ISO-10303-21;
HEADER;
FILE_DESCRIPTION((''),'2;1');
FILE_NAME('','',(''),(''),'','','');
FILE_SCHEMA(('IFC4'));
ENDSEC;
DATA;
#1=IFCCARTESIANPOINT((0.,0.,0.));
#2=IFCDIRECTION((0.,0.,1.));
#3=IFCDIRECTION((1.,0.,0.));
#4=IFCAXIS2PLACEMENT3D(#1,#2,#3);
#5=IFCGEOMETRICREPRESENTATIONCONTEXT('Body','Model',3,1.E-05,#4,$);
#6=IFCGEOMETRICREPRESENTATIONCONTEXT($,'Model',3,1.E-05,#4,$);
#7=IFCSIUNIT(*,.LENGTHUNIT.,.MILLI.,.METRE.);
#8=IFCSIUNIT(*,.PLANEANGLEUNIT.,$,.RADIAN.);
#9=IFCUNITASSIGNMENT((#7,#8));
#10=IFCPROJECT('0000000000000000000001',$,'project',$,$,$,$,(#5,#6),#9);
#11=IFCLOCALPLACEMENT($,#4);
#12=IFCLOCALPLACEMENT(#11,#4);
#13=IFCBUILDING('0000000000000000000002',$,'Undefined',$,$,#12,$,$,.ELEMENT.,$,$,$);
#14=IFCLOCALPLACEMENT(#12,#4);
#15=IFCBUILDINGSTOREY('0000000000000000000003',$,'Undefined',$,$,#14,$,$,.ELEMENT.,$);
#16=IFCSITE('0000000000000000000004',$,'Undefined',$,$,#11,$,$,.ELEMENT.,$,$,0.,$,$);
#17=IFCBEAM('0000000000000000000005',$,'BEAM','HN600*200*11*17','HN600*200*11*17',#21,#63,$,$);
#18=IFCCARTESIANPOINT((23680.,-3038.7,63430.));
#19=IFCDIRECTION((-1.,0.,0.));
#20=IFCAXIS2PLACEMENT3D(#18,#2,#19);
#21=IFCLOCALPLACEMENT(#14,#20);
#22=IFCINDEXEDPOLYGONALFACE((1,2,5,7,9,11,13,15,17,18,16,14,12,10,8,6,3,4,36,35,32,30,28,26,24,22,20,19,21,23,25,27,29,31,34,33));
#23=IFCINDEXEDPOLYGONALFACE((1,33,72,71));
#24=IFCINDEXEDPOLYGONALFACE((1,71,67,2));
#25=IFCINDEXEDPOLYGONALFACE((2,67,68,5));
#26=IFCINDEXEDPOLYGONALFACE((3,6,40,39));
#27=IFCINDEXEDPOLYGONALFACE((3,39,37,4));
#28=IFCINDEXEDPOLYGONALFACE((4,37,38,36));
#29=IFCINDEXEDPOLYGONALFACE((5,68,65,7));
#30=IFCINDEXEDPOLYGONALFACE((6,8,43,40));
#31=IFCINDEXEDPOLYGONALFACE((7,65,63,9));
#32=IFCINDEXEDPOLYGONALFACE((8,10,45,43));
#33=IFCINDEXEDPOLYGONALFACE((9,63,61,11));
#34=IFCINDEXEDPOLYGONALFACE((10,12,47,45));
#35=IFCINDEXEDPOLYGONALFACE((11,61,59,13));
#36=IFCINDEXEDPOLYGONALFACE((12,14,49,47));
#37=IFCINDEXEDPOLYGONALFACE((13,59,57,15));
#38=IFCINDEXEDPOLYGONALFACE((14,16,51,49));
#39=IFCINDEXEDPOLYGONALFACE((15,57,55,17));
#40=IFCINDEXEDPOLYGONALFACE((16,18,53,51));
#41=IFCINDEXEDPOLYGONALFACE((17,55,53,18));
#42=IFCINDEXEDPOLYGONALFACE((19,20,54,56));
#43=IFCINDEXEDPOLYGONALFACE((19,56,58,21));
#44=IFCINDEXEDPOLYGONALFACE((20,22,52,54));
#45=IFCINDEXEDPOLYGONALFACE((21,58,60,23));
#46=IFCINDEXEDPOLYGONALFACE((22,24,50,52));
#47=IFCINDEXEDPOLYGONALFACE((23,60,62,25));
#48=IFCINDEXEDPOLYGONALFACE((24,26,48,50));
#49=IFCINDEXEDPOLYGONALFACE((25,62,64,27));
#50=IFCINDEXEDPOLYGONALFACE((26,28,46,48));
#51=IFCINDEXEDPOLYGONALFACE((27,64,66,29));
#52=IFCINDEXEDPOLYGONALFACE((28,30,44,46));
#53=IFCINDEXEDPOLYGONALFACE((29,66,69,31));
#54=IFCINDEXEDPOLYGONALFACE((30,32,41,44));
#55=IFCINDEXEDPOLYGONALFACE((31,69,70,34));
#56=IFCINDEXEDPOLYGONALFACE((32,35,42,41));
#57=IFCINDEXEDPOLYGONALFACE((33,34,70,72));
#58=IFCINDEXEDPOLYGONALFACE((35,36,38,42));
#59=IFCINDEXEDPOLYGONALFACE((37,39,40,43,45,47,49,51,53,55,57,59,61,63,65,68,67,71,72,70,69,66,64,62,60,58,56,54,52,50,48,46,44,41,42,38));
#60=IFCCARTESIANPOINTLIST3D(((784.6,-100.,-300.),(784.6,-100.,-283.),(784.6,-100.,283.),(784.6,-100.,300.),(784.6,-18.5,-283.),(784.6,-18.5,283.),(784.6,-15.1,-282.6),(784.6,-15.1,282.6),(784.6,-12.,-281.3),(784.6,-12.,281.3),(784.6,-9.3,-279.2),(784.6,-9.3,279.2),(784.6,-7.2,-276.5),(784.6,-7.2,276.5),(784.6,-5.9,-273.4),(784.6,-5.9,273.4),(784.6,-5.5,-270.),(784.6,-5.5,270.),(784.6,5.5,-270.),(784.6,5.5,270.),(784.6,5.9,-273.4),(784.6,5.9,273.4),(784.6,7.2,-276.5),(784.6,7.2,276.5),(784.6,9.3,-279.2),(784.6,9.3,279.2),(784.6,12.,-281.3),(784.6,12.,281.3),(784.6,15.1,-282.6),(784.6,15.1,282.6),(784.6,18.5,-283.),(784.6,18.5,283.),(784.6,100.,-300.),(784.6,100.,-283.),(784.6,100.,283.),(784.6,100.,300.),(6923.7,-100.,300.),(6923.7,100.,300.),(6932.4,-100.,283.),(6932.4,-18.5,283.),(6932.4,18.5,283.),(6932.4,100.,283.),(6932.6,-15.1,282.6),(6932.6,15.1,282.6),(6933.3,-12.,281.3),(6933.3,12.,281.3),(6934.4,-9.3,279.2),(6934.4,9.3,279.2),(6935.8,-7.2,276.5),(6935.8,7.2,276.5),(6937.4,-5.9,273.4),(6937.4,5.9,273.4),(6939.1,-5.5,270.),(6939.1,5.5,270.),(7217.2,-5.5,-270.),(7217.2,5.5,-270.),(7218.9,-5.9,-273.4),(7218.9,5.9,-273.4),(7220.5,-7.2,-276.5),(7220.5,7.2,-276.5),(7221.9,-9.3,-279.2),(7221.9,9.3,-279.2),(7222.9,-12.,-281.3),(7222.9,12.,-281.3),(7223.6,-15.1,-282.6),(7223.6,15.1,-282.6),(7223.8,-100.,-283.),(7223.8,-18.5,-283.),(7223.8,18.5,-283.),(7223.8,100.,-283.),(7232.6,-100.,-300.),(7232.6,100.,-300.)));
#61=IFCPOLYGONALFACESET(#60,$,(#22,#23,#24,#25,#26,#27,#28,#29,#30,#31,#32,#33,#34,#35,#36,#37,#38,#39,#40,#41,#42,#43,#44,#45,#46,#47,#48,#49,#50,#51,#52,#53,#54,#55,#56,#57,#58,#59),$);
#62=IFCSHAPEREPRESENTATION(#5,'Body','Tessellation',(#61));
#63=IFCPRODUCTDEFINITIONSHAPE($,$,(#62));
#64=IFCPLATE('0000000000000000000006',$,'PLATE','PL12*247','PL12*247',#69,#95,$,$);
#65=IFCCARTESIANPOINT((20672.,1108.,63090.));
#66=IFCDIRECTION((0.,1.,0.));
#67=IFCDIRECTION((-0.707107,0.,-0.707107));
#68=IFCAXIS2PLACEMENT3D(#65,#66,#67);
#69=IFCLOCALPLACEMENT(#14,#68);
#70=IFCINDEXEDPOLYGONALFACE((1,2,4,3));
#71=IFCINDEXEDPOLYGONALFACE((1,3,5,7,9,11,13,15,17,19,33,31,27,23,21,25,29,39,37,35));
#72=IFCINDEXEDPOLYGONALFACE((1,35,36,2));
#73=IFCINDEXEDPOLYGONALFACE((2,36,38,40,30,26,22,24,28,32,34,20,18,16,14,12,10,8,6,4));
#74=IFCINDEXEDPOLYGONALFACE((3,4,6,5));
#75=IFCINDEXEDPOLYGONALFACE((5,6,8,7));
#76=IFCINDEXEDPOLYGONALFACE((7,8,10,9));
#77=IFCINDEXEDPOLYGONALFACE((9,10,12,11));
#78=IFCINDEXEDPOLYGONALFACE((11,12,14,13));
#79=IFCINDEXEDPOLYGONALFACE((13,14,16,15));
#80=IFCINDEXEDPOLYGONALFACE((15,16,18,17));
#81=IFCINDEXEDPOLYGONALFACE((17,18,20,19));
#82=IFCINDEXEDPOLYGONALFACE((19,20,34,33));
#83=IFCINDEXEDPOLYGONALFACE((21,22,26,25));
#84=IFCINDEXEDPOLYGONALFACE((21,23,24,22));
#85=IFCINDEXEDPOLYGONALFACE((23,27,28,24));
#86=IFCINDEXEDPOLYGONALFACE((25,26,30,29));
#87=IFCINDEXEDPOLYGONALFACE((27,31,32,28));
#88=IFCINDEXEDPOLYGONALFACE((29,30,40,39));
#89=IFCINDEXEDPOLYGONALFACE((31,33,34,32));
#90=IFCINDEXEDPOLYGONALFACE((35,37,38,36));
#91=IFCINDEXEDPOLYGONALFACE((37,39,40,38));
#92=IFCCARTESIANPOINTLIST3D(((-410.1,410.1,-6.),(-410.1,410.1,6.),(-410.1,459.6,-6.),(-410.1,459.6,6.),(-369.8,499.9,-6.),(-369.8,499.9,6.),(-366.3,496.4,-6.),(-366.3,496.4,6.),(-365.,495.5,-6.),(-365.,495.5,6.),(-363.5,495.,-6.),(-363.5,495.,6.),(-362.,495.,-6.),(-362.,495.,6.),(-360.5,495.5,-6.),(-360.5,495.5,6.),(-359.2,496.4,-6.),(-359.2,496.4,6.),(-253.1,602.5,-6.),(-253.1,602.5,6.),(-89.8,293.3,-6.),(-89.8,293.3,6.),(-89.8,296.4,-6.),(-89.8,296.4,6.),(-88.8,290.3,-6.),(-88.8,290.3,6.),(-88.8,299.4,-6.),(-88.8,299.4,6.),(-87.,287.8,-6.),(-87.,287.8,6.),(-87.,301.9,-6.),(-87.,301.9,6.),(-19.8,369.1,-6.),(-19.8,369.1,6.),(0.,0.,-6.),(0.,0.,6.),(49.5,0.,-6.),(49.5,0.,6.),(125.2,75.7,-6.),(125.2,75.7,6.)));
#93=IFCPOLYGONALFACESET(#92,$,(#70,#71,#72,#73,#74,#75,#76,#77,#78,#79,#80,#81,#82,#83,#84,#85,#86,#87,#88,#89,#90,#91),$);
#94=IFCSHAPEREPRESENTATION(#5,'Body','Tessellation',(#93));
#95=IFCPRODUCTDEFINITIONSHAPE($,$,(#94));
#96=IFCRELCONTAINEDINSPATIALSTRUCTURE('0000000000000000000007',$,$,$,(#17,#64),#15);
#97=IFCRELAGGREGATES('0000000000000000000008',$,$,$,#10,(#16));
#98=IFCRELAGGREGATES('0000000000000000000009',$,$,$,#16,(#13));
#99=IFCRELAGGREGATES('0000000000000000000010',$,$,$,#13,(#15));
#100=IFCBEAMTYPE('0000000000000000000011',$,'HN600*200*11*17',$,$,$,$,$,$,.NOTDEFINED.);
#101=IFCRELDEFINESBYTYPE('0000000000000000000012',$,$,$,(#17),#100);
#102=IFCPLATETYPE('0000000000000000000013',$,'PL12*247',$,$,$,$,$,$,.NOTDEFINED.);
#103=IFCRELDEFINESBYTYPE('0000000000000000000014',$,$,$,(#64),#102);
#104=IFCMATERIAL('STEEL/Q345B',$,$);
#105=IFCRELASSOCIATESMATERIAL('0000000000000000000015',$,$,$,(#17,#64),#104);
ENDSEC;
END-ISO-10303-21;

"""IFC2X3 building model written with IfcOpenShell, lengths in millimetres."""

from ifc_helpers import new_model, si_unit, frame, origin_with_axes, origin_2d_with_axis, place, context, project, spatial, polyline, i_section, outline, extrude, clip, halfspace, material, type_object, element, save


model = new_model("IFC2X3")

# Units and contexts
model_context_1 = context("Model", 3, precision=1e-05, world=origin_with_axes(), identifier="Body")
model_context_2 = context("Model", 3, precision=1e-05, world=origin_with_axes())
ifc_project = project(units=[si_unit("LENGTHUNIT", "METRE", prefix="MILLI"), si_unit("PLANEANGLEUNIT", "RADIAN")], contexts=[model_context_1, model_context_2])

# Site, building, storey
site_placement = place(None, origin_with_axes())
site = spatial("IfcSite", under=ifc_project, at=site_placement, Name="Undefined", CompositionType="ELEMENT", RefElevation=0.0)
building_placement = place(site_placement, origin_with_axes())
building = spatial("IfcBuilding", under=site, at=building_placement, Name="Undefined", CompositionType="ELEMENT")
storey_placement = place(building_placement, origin_with_axes())
storey = spatial("IfcBuildingStorey", under=building, at=storey_placement, Name="Undefined", CompositionType="ELEMENT")

# Beam
ifc_material_1 = material(Name="STEEL/Q345B")
beam_type_1 = type_object("IfcBeamType", Name="HN600*200*11*17", PredefinedType="NOTDEFINED")
beam_1_placement = place(storey_placement, frame((23680.0, -3038.7, 63430.0), z_axis=(0.0, 0.0, 1.0), x_axis=(-1.0, 0.0, 0.0)))
element("IfcBeam", 1, at=beam_1_placement, inside=storey, type_object=beam_type_1, material=ifc_material_1, Name="BEAM", Description="HN600*200*11*17", ObjectType="HN600*200*11*17", context=model_context_1, shape_type="Clipping", body=[
    clip(clip(extrude(i_section(OverallWidth=200.0, OverallDepth=600.0, WebThickness=11.0, FlangeThickness=17.0, FilletRadius=13.0, at=origin_2d_with_axis()), frame((7234.1, 0.0, 0.0), z_axis=(-1.0, 0.0, 0.0), x_axis=(0.0, -1.0, 0.0)), (0.0, 0.0, 1.0), 6449.5), halfspace(frame((6923.7, 0.0, 300.0), z_axis=(-0.88907, 0.0, -0.457771), x_axis=(0.0, -1.0, 0.0)), True)), halfspace(frame((784.6, 0.0, 1000.0), z_axis=(-1.0, 0.0, 0.0), x_axis=(0.0, -1.0, 0.0)), False)),
])

# Plate
plate_type_1 = type_object("IfcPlateType", Name="PL12*247", PredefinedType="NOTDEFINED")
plate_1_placement = place(storey_placement, frame((20672.0, 1108.0, 63090.0), z_axis=(0.0, 1.0, 0.0), x_axis=(-0.707107, 0.0, -0.707107)))
element("IfcPlate", 2, at=plate_1_placement, inside=storey, type_object=plate_type_1, material=ifc_material_1, Name="PLATE", Description="PL12*247", ObjectType="PL12*247", context=model_context_1, shape_type="SweptSolid", body=[
    extrude(outline(polyline([(0.0, 0.0), (49.5, 0.0), (125.2, 75.7), (-87.0, 287.8), (-88.8, 290.3), (-89.8, 293.3), (-89.8, 296.4), (-88.8, 299.4), (-87.0, 301.9), (-19.8, 369.1), (-253.1, 602.5), (-359.2, 496.4), (-360.5, 495.5), (-362.0, 495.0), (-363.5, 495.0), (-365.0, 495.5), (-366.3, 496.4), (-369.8, 499.9), (-410.1, 459.6), (-410.1, 410.1), (0.0, 0.0)])), frame((0.0, 0.0, -6.0), z_axis=(0.0, 0.0, 1.0), x_axis=(1.0, 0.0, 0.0)), (0.0, 0.0, 1.0), 12.0),
])

save(model, "model.ifc")
